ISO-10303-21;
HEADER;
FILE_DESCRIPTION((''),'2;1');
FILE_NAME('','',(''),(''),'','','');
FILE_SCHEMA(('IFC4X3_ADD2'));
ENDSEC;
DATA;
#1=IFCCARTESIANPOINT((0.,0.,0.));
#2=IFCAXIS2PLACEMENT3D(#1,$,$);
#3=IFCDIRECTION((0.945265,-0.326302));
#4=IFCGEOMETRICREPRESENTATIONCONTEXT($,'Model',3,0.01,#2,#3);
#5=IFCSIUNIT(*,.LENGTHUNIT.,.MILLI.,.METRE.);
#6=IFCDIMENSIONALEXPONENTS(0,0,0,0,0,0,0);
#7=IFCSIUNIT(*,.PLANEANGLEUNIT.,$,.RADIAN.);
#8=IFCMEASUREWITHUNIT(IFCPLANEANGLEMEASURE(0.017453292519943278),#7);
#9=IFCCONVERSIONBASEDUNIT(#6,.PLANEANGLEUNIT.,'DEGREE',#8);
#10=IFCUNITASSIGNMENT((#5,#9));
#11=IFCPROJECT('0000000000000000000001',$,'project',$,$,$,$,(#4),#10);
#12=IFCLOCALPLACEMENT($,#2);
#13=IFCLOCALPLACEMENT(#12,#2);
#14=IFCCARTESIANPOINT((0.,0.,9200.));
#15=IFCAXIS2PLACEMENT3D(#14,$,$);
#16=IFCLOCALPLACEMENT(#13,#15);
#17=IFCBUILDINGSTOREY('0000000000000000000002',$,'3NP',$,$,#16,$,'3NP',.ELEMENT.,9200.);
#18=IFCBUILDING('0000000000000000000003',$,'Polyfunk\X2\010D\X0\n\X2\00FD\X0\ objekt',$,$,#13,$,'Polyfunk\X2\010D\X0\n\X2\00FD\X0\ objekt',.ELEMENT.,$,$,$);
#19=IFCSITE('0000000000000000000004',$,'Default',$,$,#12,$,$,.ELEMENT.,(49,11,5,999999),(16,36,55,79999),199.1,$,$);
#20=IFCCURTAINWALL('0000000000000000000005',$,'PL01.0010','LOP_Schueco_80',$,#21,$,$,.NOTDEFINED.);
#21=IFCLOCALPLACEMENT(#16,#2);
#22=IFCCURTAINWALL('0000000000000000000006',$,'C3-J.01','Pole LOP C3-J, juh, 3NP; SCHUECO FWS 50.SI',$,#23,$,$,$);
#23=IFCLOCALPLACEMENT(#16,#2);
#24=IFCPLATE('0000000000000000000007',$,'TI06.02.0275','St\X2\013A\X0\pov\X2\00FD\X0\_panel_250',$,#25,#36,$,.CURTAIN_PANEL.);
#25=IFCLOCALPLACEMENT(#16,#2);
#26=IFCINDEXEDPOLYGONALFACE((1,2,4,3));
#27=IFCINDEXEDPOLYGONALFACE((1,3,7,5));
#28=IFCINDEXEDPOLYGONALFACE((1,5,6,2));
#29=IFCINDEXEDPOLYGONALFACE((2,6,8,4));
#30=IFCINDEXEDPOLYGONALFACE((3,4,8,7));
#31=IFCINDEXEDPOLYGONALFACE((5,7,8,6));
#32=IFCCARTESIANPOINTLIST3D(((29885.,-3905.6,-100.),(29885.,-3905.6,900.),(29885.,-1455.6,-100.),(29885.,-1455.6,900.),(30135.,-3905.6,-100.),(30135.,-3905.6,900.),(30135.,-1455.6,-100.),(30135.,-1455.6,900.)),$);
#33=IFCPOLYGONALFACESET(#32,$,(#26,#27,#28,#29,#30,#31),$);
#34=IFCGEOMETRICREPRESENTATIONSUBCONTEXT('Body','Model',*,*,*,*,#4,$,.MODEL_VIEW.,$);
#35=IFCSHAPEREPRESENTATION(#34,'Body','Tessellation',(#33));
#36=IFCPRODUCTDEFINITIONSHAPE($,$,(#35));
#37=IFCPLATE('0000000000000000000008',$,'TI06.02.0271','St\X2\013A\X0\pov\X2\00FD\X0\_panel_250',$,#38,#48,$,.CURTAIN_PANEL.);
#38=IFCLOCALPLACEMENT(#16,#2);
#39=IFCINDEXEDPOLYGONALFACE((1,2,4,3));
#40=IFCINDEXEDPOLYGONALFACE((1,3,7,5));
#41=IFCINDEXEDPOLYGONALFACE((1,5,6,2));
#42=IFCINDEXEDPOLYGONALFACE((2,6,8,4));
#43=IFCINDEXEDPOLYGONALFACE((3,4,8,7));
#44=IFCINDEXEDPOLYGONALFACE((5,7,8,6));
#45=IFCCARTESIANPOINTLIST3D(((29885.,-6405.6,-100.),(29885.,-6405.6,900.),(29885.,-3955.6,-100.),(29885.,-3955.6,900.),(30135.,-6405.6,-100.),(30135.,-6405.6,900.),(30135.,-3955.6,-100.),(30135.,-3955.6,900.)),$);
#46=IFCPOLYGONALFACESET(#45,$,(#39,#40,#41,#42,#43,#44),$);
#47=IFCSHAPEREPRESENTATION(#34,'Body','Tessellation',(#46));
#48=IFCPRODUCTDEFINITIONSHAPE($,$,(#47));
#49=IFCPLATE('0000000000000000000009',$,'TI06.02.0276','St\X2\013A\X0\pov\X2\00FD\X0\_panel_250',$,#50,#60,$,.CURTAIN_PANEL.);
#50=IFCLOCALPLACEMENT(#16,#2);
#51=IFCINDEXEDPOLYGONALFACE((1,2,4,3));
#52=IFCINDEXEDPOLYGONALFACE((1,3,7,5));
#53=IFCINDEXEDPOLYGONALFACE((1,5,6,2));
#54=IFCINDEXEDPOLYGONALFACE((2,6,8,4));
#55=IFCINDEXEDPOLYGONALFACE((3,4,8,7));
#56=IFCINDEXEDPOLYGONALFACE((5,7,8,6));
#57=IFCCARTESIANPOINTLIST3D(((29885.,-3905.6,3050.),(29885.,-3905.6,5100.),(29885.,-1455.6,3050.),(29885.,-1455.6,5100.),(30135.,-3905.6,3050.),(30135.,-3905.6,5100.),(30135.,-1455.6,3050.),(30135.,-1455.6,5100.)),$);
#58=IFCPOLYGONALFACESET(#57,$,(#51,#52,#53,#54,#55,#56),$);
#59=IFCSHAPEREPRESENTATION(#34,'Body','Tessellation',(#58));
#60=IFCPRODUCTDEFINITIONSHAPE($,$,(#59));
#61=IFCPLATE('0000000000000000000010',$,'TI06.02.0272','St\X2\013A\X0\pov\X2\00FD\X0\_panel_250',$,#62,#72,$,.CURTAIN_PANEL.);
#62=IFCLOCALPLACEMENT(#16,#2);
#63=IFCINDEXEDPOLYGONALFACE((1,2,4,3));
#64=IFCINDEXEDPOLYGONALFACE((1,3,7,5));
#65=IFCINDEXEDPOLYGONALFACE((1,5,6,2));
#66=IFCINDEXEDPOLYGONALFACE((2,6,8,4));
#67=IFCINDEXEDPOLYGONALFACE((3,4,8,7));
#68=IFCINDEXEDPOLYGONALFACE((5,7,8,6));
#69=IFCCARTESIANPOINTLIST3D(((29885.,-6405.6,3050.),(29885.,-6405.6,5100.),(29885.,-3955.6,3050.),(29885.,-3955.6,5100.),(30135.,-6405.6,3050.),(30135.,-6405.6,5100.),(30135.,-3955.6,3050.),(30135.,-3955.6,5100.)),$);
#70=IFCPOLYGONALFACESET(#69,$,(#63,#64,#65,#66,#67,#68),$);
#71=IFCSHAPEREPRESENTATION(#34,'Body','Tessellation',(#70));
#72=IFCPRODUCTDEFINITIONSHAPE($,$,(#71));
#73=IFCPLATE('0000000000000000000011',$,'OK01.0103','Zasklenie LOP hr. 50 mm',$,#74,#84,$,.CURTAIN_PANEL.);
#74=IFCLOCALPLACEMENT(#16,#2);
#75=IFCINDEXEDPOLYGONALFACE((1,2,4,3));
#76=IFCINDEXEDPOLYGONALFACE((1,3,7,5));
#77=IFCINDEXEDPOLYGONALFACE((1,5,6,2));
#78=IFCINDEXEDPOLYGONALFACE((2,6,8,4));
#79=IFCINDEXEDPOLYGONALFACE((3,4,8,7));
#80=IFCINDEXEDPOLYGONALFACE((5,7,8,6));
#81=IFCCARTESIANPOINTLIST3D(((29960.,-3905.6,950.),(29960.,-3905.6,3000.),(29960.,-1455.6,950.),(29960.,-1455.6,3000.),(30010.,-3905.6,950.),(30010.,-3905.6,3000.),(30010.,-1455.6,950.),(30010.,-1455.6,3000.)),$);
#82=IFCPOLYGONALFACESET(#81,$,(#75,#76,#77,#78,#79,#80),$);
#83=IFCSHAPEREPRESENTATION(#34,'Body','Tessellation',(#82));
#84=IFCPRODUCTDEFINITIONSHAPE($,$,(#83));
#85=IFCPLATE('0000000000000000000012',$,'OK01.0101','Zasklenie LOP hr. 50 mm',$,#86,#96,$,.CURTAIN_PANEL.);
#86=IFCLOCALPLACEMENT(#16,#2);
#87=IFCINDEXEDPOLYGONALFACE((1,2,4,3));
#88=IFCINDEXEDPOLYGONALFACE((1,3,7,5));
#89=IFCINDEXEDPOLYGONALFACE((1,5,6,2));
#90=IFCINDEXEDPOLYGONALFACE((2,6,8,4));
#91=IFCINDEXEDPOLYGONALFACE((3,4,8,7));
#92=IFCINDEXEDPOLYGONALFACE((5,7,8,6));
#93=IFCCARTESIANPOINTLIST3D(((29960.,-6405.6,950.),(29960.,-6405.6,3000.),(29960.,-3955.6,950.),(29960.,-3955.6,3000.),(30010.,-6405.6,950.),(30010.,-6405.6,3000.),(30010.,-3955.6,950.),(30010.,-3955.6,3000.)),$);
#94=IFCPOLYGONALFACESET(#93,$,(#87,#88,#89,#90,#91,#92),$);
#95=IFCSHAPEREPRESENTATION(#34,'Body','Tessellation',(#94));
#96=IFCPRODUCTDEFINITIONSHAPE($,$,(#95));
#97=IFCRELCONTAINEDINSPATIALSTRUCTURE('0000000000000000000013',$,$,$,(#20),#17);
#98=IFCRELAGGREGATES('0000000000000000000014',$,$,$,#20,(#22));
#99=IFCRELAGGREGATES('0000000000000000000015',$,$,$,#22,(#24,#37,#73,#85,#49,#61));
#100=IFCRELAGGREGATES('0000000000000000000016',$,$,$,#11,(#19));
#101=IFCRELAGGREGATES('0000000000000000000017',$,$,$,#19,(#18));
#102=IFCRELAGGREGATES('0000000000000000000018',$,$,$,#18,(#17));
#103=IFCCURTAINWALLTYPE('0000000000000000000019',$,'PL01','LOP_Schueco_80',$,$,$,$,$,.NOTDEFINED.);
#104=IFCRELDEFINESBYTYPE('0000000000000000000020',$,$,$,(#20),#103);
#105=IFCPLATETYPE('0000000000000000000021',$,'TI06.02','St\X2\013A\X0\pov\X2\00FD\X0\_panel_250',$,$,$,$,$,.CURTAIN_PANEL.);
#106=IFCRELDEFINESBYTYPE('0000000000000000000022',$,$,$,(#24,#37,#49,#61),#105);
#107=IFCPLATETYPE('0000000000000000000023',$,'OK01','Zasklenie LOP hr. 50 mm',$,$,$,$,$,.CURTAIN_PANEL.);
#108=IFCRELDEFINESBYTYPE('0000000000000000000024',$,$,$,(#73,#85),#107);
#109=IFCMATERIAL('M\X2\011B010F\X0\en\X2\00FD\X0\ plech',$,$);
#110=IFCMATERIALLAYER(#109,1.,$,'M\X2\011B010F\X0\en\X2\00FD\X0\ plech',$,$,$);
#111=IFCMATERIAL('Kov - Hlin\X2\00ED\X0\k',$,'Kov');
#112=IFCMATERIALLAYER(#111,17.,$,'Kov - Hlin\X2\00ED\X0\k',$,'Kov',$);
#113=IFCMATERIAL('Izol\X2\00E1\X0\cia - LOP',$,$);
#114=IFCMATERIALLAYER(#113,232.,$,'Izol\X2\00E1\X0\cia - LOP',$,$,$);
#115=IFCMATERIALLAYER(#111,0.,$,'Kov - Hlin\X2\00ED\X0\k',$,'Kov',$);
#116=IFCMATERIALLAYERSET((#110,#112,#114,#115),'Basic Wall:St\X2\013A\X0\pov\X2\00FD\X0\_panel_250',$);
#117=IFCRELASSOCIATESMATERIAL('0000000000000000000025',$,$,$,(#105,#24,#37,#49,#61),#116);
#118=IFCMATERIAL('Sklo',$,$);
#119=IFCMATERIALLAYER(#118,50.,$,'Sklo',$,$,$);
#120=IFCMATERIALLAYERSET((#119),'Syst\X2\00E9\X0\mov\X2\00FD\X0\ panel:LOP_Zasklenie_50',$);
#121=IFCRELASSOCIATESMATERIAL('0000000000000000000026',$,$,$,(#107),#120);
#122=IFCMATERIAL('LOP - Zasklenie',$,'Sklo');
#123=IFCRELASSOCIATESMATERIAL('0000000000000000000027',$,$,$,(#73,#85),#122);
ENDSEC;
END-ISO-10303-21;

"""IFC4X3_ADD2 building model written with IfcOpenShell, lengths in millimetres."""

from ifc_helpers import new_model, entity, si_unit, converted_unit, direction, frame, frame_2d, origin, origin_2d_with_axis, place, context, subcontext, project, spatial, rectangle, extrude, source, transform, mapped, material, layer, layer_set, layer_usage, type_object, type_shapes, element, aggregate, save


model = new_model("IFC4X3_ADD2")

# Units and contexts
model_context = context("Model", 3, precision=0.01, world=origin(), true_north=direction((0.945265, -0.326302)))
body_context = subcontext(model_context, "Body", "Model", "MODEL_VIEW")
ifc_project = project(units=[si_unit("LENGTHUNIT", "METRE", prefix="MILLI"), converted_unit("PLANEANGLEUNIT", "DEGREE", entity("IfcPlaneAngleMeasure", 0.017453292519943278), si_unit("PLANEANGLEUNIT", "RADIAN"), dimensions=[0, 0, 0, 0, 0, 0, 0])], contexts=[model_context])

# Site, building, storey
site_placement = place(None, origin())
site = spatial("IfcSite", under=ifc_project, at=site_placement, Name="Default", CompositionType="ELEMENT", RefLatitude=(49, 11, 5, 999999), RefLongitude=(16, 36, 55, 79999), RefElevation=199.1)
building_placement = place(site_placement, origin())
building = spatial("IfcBuilding", under=site, at=building_placement, Name="Polyfunkčný objekt", LongName="Polyfunkčný objekt", CompositionType="ELEMENT")
storey_placement = place(building_placement, frame((0.0, 0.0, 9200.0)))
storey = spatial("IfcBuildingStorey", under=building, at=storey_placement, Name="3NP", LongName="3NP", CompositionType="ELEMENT", Elevation=9200.0)

# Curtain walls, plates
curtain_wall_type = type_object("IfcCurtainWallType", Name="PL01", Description="LOP_Schueco_80", PredefinedType="NOTDEFINED")
curtain_wall_1_placement = place(storey_placement, frame((0.0, 0.0, -9200.0)))
curtain_wall_1 = element("IfcCurtainWall", 1, at=curtain_wall_1_placement, inside=storey, type_object=curtain_wall_type, Name="PL01.0010", Description="LOP_Schueco_80", PredefinedType="NOTDEFINED")
curtain_wall_2 = element("IfcCurtainWall", 2, Name="C3-J.01", Description="Pole LOP C3-J, juh, 3NP; SCHUECO FWS 50.SI")
aggregate(curtain_wall_1, [curtain_wall_2])
ifc_material_1 = material(Name="Měďený plech")
ifc_layer_1 = layer(ifc_material_1, 1.0, Name="Měďený plech")
ifc_material_2 = material(Name="Kov - Hliník", Category="Kov")
ifc_layer_2 = layer(ifc_material_2, 17.0, Name="Kov - Hliník", Category="Kov")
ifc_material_3 = material(Name="Izolácia - LOP")
ifc_layer_3 = layer(ifc_material_3, 232.0, Name="Izolácia - LOP")
ifc_layer_4 = layer(ifc_material_2, 0.0, Name="Kov - Hliník", Category="Kov")
ifc_layer_set_1 = layer_set([ifc_layer_1, ifc_layer_2, ifc_layer_3, ifc_layer_4], Name="Basic Wall:Stĺpový_panel_250")
ifc_layer_usage_1 = layer_usage(ifc_layer_set_1, "AXIS2", "POSITIVE", -125.0)
plate_type_1 = type_object("IfcPlateType", Name="TI06.02", Description="Stĺpový_panel_250", PredefinedType="CURTAIN_PANEL", material=ifc_layer_set_1)
plate_1_placement = place(storey_placement, frame((30010.0, -1455.6, -100.0), z_axis=(0.0, 0.0, 1.0), x_axis=(0.0, -1.0, 0.0)))
plate_1 = element("IfcPlate", 3, at=plate_1_placement, type_object=plate_type_1, material=ifc_layer_usage_1, Name="TI06.02.0275", Description="Stĺpový_panel_250", PredefinedType="CURTAIN_PANEL", context=body_context, shape_type="SweptSolid", body=[
    extrude(rectangle(XDim=250.0, YDim=2450.0, at=origin_2d_with_axis()), frame((1225.0, 0.0, 0.0), z_axis=(0.0, 0.0, 1.0), x_axis=(0.0, 1.0, 0.0)), (0.0, 0.0, 1.0), 1000.0),
])
ifc_layer_usage_2 = layer_usage(ifc_layer_set_1, "AXIS2", "POSITIVE", -125.0)
plate_2_placement = place(storey_placement, frame((30010.0, -3955.6, -100.0), z_axis=(0.0, 0.0, 1.0), x_axis=(0.0, -1.0, 0.0)))
plate_2 = element("IfcPlate", 4, at=plate_2_placement, type_object=plate_type_1, material=ifc_layer_usage_2, Name="TI06.02.0271", Description="Stĺpový_panel_250", PredefinedType="CURTAIN_PANEL", context=body_context, shape_type="SweptSolid", body=[
    extrude(rectangle(XDim=250.0, YDim=2450.0, at=frame_2d((0.0, 0.0), x_axis=(1.0, 0.0))), frame((1225.0, 0.0, 0.0), z_axis=(0.0, 0.0, 1.0), x_axis=(0.0, 1.0, 0.0)), (0.0, 0.0, 1.0), 1000.0),
])
ifc_layer_usage_3 = layer_usage(ifc_layer_set_1, "AXIS2", "POSITIVE", -125.0)
plate_3_placement = place(storey_placement, frame((30010.0, -1455.6, 3050.0), z_axis=(0.0, 0.0, 1.0), x_axis=(0.0, -1.0, 0.0)))
plate_3 = element("IfcPlate", 5, at=plate_3_placement, type_object=plate_type_1, material=ifc_layer_usage_3, Name="TI06.02.0276", Description="Stĺpový_panel_250", PredefinedType="CURTAIN_PANEL", context=body_context, shape_type="SweptSolid", body=[
    extrude(rectangle(XDim=250.0, YDim=2450.0, at=origin_2d_with_axis()), frame((1225.0, 0.0, 0.0), z_axis=(0.0, 0.0, 1.0), x_axis=(0.0, 1.0, 0.0)), (0.0, 0.0, 1.0), 2050.0),
])
ifc_layer_usage_4 = layer_usage(ifc_layer_set_1, "AXIS2", "POSITIVE", -125.0)
plate_4_placement = place(storey_placement, frame((30010.0, -3955.6, 3050.0), z_axis=(0.0, 0.0, 1.0), x_axis=(0.0, -1.0, 0.0)))
plate_4 = element("IfcPlate", 6, at=plate_4_placement, type_object=plate_type_1, material=ifc_layer_usage_4, Name="TI06.02.0272", Description="Stĺpový_panel_250", PredefinedType="CURTAIN_PANEL", context=body_context, shape_type="SweptSolid", body=[
    extrude(rectangle(XDim=250.0, YDim=2450.0, at=frame_2d((0.0, 0.0), x_axis=(1.0, 0.0))), frame((1225.0, 0.0, 0.0), z_axis=(0.0, 0.0, 1.0), x_axis=(0.0, 1.0, 0.0)), (0.0, 0.0, 1.0), 2050.0),
])
ifc_material_4 = material(Name="LOP - Zasklenie", Category="Sklo")
ifc_material_5 = material(Name="Sklo")
ifc_layer_5 = layer(ifc_material_5, 50.0, Name="Sklo")
ifc_layer_set_2 = layer_set([ifc_layer_5], Name="Systémový panel:LOP_Zasklenie_50")
plate_type_2 = type_object("IfcPlateType", Name="OK01", Description="Zasklenie LOP hr. 50 mm", PredefinedType="CURTAIN_PANEL", material=ifc_layer_set_2)
shared_shape_1 = source(origin(), body_context, "Body", "SweptSolid", [
    extrude(rectangle(XDim=50.0, YDim=2450.0, at=origin_2d_with_axis()), frame((0.0, -25.0, 0.0), z_axis=(0.0, 0.0, 1.0), x_axis=(0.0, 1.0, 0.0)), (0.0, 0.0, 1.0), 2050.0),
])
type_shapes(plate_type_2, [shared_shape_1])
plate_5_placement = place(curtain_wall_1_placement, frame((30010.0, -2680.6, 10150.0), z_axis=(0.0, 0.0, 1.0), x_axis=(0.0, -1.0, 0.0)))
plate_5 = element("IfcPlate", 7, at=plate_5_placement, type_object=plate_type_2, material=ifc_material_4, Name="OK01.0103", Description="Zasklenie LOP hr. 50 mm", PredefinedType="CURTAIN_PANEL", context=body_context, shape_type="MappedRepresentation", body=[
    mapped(shared_shape_1, transform((0.0, 0.0, 0.0), scale=1.0)),
])
plate_6_placement = place(curtain_wall_1_placement, frame((30010.0, -5180.6, 10150.0), z_axis=(0.0, 0.0, 1.0), x_axis=(0.0, -1.0, 0.0)))
plate_6 = element("IfcPlate", 8, at=plate_6_placement, type_object=plate_type_2, material=ifc_material_4, Name="OK01.0101", Description="Zasklenie LOP hr. 50 mm", PredefinedType="CURTAIN_PANEL", context=body_context, shape_type="MappedRepresentation", body=[
    mapped(shared_shape_1, transform((0.0, 0.0, 0.0), scale=1.0)),
])
aggregate(curtain_wall_2, [plate_1, plate_2, plate_5, plate_6, plate_3, plate_4])

save(model, "model.ifc")
